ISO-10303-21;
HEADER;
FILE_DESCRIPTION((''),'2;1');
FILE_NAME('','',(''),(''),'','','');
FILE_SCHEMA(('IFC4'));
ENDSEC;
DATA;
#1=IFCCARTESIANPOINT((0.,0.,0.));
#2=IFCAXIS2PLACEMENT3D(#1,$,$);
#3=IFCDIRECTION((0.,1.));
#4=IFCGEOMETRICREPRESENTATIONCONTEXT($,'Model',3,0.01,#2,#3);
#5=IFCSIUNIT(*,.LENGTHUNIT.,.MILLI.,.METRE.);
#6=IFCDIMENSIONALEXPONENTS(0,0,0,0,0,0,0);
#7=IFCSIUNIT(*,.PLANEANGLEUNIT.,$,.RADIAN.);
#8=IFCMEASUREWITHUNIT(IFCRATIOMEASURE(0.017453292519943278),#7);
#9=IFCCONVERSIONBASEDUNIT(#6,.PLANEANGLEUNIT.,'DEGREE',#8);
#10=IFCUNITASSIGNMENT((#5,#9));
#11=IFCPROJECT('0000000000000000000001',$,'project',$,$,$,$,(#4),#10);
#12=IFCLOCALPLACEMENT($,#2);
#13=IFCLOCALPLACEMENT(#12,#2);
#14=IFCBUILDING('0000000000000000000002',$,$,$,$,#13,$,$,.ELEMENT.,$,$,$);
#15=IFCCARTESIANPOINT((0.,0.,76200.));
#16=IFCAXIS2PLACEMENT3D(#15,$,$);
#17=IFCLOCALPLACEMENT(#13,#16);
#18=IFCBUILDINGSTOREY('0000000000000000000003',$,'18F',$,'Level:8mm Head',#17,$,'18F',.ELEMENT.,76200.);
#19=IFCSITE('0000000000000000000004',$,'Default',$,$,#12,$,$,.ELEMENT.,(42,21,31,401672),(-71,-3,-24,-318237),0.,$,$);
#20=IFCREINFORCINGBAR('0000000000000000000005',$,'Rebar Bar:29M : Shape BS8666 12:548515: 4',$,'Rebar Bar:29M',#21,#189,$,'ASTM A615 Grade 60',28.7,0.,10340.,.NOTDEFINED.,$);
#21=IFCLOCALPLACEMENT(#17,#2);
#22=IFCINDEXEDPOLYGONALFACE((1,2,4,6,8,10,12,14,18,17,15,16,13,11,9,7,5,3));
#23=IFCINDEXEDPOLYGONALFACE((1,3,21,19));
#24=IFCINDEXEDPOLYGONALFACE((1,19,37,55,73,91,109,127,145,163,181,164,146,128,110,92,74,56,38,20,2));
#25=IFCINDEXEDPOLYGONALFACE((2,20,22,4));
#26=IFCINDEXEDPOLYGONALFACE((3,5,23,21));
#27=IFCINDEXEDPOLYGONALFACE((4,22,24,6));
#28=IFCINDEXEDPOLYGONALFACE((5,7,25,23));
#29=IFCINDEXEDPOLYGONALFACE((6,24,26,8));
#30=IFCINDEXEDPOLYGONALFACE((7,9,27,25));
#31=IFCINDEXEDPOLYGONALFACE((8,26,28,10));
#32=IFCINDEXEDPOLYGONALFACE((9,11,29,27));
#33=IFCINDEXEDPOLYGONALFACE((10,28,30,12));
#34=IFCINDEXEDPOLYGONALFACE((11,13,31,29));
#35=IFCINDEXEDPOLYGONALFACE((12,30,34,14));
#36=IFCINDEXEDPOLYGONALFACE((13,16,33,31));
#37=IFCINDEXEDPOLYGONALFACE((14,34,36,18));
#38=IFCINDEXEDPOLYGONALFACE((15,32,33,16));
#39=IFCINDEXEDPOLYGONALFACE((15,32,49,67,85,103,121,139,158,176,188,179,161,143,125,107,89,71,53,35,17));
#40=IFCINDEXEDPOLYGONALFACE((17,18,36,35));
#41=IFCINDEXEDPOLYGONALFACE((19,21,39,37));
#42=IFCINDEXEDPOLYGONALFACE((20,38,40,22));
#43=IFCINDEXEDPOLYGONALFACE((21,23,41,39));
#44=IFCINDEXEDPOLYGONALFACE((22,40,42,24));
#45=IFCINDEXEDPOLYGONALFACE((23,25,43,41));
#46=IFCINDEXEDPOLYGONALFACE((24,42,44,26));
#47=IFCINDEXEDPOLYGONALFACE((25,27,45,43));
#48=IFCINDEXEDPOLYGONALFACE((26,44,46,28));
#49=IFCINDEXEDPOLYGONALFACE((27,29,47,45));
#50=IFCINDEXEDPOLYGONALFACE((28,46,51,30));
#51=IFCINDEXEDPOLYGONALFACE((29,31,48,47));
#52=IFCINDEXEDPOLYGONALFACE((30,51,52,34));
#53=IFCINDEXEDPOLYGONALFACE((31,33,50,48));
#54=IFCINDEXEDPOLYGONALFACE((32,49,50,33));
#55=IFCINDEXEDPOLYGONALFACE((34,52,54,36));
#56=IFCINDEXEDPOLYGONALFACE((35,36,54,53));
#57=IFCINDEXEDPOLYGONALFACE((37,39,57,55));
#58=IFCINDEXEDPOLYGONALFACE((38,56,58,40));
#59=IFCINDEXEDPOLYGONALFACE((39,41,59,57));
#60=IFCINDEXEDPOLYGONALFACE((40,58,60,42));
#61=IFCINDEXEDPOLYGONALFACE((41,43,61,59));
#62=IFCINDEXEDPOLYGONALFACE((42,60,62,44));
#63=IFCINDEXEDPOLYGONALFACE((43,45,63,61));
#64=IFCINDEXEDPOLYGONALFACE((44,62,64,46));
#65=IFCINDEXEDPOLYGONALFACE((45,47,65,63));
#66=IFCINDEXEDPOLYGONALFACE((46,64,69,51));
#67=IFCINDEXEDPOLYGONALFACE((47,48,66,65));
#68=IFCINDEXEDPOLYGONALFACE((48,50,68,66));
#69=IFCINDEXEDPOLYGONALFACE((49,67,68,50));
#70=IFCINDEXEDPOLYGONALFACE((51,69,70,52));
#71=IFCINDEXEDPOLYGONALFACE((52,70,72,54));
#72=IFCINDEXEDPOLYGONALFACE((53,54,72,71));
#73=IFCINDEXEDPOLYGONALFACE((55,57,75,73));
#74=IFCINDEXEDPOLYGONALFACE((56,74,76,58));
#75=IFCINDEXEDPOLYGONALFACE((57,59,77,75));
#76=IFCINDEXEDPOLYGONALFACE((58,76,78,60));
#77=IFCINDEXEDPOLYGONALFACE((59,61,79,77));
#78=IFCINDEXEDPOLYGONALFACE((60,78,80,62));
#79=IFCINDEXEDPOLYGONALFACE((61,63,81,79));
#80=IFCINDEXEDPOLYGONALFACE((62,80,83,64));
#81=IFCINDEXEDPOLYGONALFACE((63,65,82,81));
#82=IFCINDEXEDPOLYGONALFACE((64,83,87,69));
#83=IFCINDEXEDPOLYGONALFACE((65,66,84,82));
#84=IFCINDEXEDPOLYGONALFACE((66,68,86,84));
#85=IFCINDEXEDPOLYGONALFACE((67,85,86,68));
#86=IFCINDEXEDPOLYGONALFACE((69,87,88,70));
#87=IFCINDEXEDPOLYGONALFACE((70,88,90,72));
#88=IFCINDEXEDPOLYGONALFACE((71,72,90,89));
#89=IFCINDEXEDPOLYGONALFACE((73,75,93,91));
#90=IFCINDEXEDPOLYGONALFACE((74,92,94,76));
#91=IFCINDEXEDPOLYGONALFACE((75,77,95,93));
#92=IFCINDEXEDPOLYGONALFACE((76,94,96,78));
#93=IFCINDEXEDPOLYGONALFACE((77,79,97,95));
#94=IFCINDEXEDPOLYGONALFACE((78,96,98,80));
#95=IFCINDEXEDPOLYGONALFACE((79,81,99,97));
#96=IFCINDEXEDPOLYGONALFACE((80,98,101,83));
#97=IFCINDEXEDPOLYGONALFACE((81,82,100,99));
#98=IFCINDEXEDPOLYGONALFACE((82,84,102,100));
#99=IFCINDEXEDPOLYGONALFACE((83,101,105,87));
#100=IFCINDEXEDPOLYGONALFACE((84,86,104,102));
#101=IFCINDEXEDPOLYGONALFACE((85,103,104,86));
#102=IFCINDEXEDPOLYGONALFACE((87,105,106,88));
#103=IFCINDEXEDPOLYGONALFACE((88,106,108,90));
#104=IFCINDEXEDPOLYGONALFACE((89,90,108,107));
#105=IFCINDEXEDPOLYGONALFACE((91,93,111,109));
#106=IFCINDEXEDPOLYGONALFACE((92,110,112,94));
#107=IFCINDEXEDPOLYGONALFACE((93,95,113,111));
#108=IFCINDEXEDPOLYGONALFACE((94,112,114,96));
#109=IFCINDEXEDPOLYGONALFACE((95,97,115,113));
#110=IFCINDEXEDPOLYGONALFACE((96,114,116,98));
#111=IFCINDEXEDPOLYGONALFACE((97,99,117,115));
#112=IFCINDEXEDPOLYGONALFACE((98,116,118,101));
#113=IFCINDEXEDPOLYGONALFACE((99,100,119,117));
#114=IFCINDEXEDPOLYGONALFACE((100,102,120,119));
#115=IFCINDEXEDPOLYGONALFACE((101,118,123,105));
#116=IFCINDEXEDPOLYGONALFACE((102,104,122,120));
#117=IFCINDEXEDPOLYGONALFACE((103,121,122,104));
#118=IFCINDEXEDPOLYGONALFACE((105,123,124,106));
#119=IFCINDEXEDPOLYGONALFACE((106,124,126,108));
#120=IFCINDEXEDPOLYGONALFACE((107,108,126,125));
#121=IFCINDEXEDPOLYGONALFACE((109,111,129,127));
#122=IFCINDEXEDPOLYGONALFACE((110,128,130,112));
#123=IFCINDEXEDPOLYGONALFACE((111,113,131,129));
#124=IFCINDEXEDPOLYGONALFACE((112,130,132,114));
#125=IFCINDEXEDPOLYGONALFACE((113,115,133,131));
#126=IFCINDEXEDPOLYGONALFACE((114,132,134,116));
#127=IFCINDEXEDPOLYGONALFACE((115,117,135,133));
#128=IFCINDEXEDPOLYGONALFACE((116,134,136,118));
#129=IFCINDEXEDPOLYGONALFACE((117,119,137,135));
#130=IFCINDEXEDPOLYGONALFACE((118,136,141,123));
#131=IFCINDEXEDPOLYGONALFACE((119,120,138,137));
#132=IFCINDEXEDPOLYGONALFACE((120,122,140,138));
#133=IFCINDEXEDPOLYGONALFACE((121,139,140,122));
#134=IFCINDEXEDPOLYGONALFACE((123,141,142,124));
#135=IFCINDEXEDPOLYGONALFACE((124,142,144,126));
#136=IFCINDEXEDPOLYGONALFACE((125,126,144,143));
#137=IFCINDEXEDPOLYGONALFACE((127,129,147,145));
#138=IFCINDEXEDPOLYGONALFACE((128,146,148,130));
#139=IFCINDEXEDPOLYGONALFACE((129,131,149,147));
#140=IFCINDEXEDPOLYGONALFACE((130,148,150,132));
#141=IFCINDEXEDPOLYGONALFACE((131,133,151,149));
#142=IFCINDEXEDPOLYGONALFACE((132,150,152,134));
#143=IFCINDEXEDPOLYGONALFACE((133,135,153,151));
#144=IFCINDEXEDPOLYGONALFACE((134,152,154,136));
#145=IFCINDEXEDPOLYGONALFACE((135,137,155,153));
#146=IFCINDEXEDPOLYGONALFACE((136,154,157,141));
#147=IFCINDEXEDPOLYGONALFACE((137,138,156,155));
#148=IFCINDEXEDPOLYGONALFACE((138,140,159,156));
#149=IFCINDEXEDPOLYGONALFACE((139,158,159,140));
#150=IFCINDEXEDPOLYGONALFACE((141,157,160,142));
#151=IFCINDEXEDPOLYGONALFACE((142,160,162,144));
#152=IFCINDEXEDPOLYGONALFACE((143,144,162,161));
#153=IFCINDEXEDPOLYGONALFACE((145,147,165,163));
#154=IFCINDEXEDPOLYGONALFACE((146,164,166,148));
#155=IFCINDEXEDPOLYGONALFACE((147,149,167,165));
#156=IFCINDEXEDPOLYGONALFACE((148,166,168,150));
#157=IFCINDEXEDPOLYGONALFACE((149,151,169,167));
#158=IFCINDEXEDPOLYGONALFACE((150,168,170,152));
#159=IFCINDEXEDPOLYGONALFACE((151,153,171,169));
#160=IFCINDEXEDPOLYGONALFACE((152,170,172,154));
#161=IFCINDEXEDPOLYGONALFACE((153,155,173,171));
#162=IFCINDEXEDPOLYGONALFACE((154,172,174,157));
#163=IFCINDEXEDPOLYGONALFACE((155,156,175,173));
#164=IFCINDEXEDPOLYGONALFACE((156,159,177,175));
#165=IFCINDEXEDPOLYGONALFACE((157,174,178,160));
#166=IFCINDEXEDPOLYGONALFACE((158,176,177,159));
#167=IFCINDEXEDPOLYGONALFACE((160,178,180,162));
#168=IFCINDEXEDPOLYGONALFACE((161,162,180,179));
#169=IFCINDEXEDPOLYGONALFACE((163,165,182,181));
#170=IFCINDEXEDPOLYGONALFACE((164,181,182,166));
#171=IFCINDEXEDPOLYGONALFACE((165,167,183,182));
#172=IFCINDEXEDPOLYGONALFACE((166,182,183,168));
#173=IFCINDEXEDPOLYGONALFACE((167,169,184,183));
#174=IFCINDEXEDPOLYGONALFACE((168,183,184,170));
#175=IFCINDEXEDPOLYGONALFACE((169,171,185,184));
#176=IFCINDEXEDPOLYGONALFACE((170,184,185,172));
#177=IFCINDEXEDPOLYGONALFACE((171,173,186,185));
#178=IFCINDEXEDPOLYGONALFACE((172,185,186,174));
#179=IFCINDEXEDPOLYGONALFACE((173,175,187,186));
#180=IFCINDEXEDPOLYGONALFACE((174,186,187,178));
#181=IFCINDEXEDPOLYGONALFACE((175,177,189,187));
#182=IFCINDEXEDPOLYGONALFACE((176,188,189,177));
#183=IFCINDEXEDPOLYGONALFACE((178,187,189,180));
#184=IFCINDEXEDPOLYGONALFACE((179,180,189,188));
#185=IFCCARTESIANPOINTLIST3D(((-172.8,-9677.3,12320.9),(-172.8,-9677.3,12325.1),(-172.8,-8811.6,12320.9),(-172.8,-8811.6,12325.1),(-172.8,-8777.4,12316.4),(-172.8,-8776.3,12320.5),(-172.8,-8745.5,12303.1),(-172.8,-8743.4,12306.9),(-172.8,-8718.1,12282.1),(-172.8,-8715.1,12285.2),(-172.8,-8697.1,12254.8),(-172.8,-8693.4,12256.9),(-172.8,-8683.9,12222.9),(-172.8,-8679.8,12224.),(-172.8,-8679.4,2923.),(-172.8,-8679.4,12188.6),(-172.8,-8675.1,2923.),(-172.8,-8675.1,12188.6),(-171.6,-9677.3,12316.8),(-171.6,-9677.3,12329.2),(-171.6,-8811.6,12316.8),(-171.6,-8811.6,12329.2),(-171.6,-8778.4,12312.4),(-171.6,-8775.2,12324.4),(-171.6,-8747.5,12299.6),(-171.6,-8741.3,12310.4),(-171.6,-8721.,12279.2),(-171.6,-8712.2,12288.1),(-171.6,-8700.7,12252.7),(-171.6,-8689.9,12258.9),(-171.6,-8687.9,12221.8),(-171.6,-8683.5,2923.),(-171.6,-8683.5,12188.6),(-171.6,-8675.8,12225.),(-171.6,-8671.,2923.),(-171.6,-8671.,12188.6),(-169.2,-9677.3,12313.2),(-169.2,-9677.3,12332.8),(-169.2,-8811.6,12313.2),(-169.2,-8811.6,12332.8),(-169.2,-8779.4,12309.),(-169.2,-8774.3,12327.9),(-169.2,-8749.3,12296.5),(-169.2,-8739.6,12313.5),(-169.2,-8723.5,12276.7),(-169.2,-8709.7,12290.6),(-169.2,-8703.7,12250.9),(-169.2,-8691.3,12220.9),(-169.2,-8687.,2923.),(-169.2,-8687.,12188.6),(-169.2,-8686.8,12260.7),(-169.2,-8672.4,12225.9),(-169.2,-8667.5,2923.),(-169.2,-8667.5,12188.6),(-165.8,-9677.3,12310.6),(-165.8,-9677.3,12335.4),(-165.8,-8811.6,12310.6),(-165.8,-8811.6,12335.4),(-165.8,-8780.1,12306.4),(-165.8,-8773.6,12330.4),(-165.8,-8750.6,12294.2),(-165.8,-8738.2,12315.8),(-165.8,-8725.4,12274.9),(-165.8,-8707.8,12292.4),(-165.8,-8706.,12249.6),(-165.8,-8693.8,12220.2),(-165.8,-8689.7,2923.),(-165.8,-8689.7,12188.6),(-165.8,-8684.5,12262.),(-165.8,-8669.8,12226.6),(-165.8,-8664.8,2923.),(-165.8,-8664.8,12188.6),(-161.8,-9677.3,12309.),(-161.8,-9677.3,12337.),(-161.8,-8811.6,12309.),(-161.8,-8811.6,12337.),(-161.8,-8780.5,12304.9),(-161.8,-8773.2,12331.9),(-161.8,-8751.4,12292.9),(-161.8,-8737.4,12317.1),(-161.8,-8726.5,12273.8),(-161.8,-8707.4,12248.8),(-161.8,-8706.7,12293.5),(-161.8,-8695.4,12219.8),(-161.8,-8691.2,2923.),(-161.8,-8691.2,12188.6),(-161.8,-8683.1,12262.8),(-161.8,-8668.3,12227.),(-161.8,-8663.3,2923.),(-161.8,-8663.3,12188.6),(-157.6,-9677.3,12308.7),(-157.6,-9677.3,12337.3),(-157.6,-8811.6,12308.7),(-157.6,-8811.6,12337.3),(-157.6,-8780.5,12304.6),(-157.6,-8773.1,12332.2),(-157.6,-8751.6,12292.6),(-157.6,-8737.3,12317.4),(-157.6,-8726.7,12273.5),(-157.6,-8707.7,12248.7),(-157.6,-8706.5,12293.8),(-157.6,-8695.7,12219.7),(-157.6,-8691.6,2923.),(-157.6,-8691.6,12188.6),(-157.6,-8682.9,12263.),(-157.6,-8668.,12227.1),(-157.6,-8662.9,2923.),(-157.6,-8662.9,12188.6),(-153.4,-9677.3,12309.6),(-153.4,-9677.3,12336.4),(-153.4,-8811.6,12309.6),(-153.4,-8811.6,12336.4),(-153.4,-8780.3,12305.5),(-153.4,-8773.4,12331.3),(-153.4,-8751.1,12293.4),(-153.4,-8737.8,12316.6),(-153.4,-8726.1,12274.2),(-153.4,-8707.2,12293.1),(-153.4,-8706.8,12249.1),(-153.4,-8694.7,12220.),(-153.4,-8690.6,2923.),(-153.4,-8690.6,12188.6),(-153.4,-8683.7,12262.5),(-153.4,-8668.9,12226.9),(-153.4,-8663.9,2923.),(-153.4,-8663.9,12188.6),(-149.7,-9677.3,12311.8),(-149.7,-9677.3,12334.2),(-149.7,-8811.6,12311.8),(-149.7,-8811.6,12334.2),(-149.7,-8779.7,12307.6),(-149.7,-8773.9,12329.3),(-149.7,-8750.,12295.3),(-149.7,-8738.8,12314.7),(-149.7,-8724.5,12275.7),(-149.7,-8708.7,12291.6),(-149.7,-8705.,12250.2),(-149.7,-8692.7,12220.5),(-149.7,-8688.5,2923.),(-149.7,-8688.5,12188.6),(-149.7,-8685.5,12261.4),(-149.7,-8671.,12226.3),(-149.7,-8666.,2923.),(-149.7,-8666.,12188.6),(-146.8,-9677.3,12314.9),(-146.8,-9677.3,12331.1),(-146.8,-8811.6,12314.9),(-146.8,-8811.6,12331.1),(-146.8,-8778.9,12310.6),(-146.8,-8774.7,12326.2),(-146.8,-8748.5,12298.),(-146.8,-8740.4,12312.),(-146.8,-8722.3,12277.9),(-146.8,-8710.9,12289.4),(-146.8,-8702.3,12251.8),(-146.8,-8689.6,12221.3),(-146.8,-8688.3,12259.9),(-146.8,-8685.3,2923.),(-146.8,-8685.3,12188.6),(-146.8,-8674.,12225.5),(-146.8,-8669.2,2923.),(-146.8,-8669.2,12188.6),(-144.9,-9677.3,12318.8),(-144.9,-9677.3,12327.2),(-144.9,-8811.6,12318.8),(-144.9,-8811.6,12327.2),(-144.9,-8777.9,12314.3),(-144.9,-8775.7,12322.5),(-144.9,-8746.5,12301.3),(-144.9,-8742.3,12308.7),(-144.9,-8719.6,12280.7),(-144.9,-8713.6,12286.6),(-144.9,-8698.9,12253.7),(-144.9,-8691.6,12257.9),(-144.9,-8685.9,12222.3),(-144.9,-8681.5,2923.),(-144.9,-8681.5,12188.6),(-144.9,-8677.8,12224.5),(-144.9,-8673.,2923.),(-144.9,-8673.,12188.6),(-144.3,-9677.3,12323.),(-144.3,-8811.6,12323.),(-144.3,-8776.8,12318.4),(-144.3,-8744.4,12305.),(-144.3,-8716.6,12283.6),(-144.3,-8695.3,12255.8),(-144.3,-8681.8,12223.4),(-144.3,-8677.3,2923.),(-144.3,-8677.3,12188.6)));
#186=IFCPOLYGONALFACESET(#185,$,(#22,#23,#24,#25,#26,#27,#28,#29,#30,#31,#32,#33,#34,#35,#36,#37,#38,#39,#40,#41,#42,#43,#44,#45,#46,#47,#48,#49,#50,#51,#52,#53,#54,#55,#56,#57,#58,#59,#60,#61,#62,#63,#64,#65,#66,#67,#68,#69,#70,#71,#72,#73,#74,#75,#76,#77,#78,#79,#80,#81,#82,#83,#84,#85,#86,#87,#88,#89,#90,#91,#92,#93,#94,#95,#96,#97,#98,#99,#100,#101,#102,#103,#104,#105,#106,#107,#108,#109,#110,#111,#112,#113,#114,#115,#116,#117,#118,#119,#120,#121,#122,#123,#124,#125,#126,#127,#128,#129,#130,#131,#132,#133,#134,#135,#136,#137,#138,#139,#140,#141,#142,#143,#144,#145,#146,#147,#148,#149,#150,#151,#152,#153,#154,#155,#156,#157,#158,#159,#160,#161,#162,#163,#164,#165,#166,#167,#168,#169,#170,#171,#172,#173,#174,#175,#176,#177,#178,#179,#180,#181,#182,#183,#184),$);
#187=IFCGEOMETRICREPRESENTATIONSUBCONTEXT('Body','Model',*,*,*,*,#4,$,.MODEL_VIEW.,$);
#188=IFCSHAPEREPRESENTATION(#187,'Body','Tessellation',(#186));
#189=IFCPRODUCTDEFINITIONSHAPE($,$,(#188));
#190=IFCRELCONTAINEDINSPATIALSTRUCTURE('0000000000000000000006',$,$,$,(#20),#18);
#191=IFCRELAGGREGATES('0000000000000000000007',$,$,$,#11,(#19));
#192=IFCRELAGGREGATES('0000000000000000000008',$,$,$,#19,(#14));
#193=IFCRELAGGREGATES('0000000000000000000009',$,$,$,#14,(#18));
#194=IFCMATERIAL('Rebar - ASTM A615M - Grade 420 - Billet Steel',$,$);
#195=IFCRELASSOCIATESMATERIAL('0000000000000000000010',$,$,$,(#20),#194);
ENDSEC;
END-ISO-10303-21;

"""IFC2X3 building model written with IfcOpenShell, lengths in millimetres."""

from ifc_helpers import new_model, entity, si_unit, converted_unit, direction, frame, origin, place, context, subcontext, project, spatial, material, element, save


model = new_model("IFC2X3")

# Units and contexts
model_context = context("Model", 3, precision=0.01, world=origin(), true_north=direction((0.0, 1.0)))
body_context = subcontext(model_context, "Body", "Model", "MODEL_VIEW")
ifc_project = project(units=[si_unit("LENGTHUNIT", "METRE", prefix="MILLI"), converted_unit("PLANEANGLEUNIT", "DEGREE", entity("IfcRatioMeasure", 0.017453292519943278), si_unit("PLANEANGLEUNIT", "RADIAN"), dimensions=[0, 0, 0, 0, 0, 0, 0])], contexts=[model_context])

# Site, building, storey
site_placement = place(None, origin())
site = spatial("IfcSite", under=ifc_project, at=site_placement, Name="Default", CompositionType="ELEMENT", RefLatitude=(42, 21, 31, 401672), RefLongitude=(-71, -3, -24, -318237), RefElevation=0.0)
building_placement = place(site_placement, origin())
building = spatial("IfcBuilding", under=site, at=building_placement, CompositionType="ELEMENT")
storey_placement = place(building_placement, frame((0.0, 0.0, 76200.0)))
storey = spatial("IfcBuildingStorey", under=building, at=storey_placement, Name="18F", ObjectType="Level:8mm Head", LongName="18F", CompositionType="ELEMENT", Elevation=76200.0)

# Reinforcing bar
ifc_material_1 = material(Name="Rebar - ASTM A615M - Grade 420 - Billet Steel")
reinforcing_bar_1_placement = place(storey_placement, origin())
element("IfcReinforcingBar", 1, at=reinforcing_bar_1_placement, inside=storey, material=ifc_material_1, Name="Rebar Bar:29M : Shape BS8666 12:548515: 4", SteelGrade="ASTM A615 Grade 60", ObjectType="Rebar Bar:29M", BarLength=10340.0, BarRole="NOTDEFINED", CrossSectionArea=0.0, NominalDiameter=28.7, context=body_context, shape_type="AdvancedSweptSolid", body=[
    entity("IfcSweptDiskSolid", entity("IfcCompositeCurve", [entity("IfcCompositeCurveSegment", "CONTINUOUS", True, entity("IfcPolyline", [entity("IfcCartesianPoint", [-158.6, -8677.3, 2923.0]), entity("IfcCartesianPoint", [-158.6, -8677.3, 12188.6])])), entity("IfcCompositeCurveSegment", "CONTINUOUS", True, entity("IfcTrimmedCurve", entity("IfcCircle", entity("IfcAxis2Placement3D", entity("IfcCartesianPoint", [-158.6, -8811.6, 12188.6]), entity("IfcDirection", [1.0, 0.0, 0.0]), entity("IfcDirection", [0.0, 0.0, 1.0])), 134.3), [entity("IfcParameterValue", 270.0)], [entity("IfcParameterValue", 360.0)], True, "PARAMETER")), entity("IfcCompositeCurveSegment", "CONTINUOUS", True, entity("IfcPolyline", [entity("IfcCartesianPoint", [-158.6, -8811.6, 12323.0]), entity("IfcCartesianPoint", [-158.6, -9677.3, 12323.0])]))], False), 14.3, None, 0.0, 92.0),
])

save(model, "model.ifc")
